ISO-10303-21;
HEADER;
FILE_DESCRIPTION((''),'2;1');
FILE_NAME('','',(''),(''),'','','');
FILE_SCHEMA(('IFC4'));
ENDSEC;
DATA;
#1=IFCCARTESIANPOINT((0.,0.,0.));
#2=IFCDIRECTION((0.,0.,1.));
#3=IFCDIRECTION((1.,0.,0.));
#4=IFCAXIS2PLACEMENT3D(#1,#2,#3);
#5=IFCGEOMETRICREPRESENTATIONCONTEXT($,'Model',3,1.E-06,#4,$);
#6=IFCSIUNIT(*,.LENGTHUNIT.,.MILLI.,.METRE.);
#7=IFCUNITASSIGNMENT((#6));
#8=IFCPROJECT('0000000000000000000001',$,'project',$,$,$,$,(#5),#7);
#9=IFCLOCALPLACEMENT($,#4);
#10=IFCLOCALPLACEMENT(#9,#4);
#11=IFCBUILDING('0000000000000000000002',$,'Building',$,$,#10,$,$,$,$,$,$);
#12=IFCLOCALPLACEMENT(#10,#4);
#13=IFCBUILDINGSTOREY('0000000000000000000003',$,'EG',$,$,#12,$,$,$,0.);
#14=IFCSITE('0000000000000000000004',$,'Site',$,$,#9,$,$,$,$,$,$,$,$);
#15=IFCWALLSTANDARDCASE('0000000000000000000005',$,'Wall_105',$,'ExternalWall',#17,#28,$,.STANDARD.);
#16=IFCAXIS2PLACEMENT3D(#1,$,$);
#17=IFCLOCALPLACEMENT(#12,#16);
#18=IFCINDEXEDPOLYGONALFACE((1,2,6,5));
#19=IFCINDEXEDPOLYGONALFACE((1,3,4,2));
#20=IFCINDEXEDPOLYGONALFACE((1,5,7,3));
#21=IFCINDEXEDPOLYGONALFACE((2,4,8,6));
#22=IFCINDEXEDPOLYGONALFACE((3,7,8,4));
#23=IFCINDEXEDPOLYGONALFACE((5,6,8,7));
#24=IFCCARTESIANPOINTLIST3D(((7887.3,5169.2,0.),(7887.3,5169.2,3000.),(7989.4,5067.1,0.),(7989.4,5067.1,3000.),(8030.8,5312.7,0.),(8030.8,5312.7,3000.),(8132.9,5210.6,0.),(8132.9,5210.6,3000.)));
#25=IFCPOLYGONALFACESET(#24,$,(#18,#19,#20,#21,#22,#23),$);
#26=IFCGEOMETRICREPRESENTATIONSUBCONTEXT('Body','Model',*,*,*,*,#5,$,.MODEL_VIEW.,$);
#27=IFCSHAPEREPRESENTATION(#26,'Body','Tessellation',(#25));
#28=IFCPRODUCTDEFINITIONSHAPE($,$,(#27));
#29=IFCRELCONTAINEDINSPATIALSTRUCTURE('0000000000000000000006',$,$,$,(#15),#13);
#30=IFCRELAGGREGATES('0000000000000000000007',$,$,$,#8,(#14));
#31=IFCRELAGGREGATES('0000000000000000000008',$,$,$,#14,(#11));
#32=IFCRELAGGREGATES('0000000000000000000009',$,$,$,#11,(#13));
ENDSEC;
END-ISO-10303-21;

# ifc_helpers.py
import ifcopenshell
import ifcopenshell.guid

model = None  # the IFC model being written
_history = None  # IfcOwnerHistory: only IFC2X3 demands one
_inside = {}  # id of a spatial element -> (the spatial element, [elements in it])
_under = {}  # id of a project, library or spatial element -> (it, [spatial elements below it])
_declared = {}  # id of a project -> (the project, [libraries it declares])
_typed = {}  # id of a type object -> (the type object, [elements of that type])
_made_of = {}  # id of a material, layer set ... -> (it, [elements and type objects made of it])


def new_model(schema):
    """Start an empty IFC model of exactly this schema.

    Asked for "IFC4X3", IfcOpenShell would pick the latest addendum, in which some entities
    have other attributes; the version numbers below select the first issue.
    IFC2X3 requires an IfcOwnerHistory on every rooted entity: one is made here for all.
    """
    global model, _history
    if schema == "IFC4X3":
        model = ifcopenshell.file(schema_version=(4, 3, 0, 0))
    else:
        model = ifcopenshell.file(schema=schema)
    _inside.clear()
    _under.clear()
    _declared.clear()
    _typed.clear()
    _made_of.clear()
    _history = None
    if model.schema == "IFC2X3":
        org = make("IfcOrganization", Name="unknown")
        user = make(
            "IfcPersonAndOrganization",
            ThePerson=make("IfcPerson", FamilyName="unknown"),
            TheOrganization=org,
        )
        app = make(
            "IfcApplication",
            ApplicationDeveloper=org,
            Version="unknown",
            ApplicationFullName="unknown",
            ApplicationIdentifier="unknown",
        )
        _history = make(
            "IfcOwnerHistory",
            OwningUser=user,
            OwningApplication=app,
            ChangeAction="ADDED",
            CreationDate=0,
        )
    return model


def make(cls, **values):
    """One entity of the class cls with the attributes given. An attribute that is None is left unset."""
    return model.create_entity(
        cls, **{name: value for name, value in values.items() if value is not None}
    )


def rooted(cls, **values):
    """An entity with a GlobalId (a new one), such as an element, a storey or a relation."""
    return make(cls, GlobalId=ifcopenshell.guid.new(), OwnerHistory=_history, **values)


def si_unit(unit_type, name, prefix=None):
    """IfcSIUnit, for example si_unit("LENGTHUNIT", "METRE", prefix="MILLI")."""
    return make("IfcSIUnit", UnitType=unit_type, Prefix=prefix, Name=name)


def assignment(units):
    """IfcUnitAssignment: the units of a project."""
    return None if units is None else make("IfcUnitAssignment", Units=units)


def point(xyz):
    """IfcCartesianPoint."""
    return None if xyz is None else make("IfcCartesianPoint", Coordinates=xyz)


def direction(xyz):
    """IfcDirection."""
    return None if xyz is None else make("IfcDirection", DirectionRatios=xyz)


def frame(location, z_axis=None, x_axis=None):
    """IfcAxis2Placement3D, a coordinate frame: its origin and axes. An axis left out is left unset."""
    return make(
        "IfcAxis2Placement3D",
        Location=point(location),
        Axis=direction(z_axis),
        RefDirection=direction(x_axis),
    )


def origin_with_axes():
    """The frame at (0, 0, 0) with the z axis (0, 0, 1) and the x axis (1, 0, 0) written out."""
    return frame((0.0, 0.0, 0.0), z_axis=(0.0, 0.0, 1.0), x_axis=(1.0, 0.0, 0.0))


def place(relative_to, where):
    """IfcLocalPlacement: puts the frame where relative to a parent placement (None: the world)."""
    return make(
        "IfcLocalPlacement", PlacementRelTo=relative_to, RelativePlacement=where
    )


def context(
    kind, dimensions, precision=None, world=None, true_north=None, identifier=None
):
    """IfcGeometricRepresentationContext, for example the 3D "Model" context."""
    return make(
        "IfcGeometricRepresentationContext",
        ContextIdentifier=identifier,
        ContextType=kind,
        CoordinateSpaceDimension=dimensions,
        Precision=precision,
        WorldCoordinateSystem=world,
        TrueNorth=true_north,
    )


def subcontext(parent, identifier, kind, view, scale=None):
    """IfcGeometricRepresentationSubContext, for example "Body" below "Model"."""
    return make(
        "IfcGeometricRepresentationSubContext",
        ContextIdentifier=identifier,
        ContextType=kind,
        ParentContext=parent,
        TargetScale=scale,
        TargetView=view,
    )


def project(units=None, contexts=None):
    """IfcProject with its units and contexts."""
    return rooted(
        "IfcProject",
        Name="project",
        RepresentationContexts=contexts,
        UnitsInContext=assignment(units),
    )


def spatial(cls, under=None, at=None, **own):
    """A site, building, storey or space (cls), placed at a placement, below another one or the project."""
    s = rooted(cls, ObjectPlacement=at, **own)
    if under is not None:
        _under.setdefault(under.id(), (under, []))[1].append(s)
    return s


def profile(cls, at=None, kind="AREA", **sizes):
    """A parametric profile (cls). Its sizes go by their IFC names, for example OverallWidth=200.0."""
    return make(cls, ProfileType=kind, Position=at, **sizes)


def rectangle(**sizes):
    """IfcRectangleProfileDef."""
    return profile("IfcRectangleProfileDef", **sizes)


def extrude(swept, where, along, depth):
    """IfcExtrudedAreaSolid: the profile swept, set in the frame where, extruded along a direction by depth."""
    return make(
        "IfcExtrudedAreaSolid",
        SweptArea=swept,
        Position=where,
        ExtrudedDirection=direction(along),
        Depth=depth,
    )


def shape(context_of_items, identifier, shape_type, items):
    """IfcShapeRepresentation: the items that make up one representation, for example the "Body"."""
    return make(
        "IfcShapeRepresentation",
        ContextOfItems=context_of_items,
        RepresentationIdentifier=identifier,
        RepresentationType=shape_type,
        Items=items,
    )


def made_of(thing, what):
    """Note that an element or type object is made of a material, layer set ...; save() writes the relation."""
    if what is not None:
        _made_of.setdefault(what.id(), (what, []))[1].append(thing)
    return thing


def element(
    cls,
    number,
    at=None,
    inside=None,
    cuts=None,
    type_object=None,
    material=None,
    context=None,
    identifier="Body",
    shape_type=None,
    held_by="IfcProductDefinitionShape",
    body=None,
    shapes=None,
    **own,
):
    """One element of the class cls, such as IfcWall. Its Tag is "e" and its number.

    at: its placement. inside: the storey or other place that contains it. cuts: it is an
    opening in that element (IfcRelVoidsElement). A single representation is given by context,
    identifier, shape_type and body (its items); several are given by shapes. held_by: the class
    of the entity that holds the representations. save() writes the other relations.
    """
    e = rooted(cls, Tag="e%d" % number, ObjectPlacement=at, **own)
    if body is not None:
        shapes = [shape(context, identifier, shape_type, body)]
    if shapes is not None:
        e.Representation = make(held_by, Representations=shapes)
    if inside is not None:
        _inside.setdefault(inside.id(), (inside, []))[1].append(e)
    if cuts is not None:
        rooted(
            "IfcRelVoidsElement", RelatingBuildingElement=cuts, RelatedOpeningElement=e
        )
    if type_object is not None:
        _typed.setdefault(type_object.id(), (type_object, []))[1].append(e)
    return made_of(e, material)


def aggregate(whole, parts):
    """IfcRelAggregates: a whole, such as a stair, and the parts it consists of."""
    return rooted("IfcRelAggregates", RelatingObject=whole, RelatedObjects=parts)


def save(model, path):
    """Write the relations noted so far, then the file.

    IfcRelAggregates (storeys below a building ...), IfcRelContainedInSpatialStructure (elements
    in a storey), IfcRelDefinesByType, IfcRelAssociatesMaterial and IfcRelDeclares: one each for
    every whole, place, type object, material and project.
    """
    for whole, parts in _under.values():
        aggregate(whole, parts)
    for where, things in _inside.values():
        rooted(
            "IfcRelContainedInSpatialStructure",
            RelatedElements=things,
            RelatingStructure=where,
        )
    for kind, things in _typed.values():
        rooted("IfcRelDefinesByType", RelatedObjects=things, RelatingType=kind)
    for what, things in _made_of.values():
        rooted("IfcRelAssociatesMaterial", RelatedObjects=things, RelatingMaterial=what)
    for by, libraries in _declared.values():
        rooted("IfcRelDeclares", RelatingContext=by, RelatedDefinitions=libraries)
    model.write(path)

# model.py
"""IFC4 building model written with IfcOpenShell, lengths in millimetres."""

from ifc_helpers import new_model, si_unit, frame, origin_with_axes, place, context, subcontext, project, spatial, rectangle, extrude, element, save


model = new_model("IFC4")

# Units and contexts
model_context = context("Model", 3, precision=1e-06, world=origin_with_axes())
body_context = subcontext(model_context, "Body", "Model", "MODEL_VIEW")
ifc_project = project(units=[si_unit("LENGTHUNIT", "METRE", prefix="MILLI")], contexts=[model_context])

# Site, building, storey
site_placement = place(None, origin_with_axes())
site = spatial("IfcSite", under=ifc_project, at=site_placement, Name="Site")
building_placement = place(site_placement, origin_with_axes())
building = spatial("IfcBuilding", under=site, at=building_placement, Name="Building")
storey_placement = place(building_placement, origin_with_axes())
storey = spatial("IfcBuildingStorey", under=building, at=storey_placement, Name="EG", Elevation=0.0)

# Wall
wall_1_placement = place(storey_placement, origin_with_axes())
element("IfcWallStandardCase", 1, at=wall_1_placement, inside=storey, Name="Wall_105", ObjectType="ExternalWall", PredefinedType="STANDARD", context=body_context, shape_type="SweptSolid", body=[
    extrude(rectangle(XDim=202.9, YDim=144.5), frame((8010.1, 5189.9, 0.0), z_axis=(0.0, 0.0, 1.0), x_axis=(-0.707107, -0.707107, 0.0)), (0.0, 0.0, 1.0), 3000.0),
])

save(model, "model.ifc")
